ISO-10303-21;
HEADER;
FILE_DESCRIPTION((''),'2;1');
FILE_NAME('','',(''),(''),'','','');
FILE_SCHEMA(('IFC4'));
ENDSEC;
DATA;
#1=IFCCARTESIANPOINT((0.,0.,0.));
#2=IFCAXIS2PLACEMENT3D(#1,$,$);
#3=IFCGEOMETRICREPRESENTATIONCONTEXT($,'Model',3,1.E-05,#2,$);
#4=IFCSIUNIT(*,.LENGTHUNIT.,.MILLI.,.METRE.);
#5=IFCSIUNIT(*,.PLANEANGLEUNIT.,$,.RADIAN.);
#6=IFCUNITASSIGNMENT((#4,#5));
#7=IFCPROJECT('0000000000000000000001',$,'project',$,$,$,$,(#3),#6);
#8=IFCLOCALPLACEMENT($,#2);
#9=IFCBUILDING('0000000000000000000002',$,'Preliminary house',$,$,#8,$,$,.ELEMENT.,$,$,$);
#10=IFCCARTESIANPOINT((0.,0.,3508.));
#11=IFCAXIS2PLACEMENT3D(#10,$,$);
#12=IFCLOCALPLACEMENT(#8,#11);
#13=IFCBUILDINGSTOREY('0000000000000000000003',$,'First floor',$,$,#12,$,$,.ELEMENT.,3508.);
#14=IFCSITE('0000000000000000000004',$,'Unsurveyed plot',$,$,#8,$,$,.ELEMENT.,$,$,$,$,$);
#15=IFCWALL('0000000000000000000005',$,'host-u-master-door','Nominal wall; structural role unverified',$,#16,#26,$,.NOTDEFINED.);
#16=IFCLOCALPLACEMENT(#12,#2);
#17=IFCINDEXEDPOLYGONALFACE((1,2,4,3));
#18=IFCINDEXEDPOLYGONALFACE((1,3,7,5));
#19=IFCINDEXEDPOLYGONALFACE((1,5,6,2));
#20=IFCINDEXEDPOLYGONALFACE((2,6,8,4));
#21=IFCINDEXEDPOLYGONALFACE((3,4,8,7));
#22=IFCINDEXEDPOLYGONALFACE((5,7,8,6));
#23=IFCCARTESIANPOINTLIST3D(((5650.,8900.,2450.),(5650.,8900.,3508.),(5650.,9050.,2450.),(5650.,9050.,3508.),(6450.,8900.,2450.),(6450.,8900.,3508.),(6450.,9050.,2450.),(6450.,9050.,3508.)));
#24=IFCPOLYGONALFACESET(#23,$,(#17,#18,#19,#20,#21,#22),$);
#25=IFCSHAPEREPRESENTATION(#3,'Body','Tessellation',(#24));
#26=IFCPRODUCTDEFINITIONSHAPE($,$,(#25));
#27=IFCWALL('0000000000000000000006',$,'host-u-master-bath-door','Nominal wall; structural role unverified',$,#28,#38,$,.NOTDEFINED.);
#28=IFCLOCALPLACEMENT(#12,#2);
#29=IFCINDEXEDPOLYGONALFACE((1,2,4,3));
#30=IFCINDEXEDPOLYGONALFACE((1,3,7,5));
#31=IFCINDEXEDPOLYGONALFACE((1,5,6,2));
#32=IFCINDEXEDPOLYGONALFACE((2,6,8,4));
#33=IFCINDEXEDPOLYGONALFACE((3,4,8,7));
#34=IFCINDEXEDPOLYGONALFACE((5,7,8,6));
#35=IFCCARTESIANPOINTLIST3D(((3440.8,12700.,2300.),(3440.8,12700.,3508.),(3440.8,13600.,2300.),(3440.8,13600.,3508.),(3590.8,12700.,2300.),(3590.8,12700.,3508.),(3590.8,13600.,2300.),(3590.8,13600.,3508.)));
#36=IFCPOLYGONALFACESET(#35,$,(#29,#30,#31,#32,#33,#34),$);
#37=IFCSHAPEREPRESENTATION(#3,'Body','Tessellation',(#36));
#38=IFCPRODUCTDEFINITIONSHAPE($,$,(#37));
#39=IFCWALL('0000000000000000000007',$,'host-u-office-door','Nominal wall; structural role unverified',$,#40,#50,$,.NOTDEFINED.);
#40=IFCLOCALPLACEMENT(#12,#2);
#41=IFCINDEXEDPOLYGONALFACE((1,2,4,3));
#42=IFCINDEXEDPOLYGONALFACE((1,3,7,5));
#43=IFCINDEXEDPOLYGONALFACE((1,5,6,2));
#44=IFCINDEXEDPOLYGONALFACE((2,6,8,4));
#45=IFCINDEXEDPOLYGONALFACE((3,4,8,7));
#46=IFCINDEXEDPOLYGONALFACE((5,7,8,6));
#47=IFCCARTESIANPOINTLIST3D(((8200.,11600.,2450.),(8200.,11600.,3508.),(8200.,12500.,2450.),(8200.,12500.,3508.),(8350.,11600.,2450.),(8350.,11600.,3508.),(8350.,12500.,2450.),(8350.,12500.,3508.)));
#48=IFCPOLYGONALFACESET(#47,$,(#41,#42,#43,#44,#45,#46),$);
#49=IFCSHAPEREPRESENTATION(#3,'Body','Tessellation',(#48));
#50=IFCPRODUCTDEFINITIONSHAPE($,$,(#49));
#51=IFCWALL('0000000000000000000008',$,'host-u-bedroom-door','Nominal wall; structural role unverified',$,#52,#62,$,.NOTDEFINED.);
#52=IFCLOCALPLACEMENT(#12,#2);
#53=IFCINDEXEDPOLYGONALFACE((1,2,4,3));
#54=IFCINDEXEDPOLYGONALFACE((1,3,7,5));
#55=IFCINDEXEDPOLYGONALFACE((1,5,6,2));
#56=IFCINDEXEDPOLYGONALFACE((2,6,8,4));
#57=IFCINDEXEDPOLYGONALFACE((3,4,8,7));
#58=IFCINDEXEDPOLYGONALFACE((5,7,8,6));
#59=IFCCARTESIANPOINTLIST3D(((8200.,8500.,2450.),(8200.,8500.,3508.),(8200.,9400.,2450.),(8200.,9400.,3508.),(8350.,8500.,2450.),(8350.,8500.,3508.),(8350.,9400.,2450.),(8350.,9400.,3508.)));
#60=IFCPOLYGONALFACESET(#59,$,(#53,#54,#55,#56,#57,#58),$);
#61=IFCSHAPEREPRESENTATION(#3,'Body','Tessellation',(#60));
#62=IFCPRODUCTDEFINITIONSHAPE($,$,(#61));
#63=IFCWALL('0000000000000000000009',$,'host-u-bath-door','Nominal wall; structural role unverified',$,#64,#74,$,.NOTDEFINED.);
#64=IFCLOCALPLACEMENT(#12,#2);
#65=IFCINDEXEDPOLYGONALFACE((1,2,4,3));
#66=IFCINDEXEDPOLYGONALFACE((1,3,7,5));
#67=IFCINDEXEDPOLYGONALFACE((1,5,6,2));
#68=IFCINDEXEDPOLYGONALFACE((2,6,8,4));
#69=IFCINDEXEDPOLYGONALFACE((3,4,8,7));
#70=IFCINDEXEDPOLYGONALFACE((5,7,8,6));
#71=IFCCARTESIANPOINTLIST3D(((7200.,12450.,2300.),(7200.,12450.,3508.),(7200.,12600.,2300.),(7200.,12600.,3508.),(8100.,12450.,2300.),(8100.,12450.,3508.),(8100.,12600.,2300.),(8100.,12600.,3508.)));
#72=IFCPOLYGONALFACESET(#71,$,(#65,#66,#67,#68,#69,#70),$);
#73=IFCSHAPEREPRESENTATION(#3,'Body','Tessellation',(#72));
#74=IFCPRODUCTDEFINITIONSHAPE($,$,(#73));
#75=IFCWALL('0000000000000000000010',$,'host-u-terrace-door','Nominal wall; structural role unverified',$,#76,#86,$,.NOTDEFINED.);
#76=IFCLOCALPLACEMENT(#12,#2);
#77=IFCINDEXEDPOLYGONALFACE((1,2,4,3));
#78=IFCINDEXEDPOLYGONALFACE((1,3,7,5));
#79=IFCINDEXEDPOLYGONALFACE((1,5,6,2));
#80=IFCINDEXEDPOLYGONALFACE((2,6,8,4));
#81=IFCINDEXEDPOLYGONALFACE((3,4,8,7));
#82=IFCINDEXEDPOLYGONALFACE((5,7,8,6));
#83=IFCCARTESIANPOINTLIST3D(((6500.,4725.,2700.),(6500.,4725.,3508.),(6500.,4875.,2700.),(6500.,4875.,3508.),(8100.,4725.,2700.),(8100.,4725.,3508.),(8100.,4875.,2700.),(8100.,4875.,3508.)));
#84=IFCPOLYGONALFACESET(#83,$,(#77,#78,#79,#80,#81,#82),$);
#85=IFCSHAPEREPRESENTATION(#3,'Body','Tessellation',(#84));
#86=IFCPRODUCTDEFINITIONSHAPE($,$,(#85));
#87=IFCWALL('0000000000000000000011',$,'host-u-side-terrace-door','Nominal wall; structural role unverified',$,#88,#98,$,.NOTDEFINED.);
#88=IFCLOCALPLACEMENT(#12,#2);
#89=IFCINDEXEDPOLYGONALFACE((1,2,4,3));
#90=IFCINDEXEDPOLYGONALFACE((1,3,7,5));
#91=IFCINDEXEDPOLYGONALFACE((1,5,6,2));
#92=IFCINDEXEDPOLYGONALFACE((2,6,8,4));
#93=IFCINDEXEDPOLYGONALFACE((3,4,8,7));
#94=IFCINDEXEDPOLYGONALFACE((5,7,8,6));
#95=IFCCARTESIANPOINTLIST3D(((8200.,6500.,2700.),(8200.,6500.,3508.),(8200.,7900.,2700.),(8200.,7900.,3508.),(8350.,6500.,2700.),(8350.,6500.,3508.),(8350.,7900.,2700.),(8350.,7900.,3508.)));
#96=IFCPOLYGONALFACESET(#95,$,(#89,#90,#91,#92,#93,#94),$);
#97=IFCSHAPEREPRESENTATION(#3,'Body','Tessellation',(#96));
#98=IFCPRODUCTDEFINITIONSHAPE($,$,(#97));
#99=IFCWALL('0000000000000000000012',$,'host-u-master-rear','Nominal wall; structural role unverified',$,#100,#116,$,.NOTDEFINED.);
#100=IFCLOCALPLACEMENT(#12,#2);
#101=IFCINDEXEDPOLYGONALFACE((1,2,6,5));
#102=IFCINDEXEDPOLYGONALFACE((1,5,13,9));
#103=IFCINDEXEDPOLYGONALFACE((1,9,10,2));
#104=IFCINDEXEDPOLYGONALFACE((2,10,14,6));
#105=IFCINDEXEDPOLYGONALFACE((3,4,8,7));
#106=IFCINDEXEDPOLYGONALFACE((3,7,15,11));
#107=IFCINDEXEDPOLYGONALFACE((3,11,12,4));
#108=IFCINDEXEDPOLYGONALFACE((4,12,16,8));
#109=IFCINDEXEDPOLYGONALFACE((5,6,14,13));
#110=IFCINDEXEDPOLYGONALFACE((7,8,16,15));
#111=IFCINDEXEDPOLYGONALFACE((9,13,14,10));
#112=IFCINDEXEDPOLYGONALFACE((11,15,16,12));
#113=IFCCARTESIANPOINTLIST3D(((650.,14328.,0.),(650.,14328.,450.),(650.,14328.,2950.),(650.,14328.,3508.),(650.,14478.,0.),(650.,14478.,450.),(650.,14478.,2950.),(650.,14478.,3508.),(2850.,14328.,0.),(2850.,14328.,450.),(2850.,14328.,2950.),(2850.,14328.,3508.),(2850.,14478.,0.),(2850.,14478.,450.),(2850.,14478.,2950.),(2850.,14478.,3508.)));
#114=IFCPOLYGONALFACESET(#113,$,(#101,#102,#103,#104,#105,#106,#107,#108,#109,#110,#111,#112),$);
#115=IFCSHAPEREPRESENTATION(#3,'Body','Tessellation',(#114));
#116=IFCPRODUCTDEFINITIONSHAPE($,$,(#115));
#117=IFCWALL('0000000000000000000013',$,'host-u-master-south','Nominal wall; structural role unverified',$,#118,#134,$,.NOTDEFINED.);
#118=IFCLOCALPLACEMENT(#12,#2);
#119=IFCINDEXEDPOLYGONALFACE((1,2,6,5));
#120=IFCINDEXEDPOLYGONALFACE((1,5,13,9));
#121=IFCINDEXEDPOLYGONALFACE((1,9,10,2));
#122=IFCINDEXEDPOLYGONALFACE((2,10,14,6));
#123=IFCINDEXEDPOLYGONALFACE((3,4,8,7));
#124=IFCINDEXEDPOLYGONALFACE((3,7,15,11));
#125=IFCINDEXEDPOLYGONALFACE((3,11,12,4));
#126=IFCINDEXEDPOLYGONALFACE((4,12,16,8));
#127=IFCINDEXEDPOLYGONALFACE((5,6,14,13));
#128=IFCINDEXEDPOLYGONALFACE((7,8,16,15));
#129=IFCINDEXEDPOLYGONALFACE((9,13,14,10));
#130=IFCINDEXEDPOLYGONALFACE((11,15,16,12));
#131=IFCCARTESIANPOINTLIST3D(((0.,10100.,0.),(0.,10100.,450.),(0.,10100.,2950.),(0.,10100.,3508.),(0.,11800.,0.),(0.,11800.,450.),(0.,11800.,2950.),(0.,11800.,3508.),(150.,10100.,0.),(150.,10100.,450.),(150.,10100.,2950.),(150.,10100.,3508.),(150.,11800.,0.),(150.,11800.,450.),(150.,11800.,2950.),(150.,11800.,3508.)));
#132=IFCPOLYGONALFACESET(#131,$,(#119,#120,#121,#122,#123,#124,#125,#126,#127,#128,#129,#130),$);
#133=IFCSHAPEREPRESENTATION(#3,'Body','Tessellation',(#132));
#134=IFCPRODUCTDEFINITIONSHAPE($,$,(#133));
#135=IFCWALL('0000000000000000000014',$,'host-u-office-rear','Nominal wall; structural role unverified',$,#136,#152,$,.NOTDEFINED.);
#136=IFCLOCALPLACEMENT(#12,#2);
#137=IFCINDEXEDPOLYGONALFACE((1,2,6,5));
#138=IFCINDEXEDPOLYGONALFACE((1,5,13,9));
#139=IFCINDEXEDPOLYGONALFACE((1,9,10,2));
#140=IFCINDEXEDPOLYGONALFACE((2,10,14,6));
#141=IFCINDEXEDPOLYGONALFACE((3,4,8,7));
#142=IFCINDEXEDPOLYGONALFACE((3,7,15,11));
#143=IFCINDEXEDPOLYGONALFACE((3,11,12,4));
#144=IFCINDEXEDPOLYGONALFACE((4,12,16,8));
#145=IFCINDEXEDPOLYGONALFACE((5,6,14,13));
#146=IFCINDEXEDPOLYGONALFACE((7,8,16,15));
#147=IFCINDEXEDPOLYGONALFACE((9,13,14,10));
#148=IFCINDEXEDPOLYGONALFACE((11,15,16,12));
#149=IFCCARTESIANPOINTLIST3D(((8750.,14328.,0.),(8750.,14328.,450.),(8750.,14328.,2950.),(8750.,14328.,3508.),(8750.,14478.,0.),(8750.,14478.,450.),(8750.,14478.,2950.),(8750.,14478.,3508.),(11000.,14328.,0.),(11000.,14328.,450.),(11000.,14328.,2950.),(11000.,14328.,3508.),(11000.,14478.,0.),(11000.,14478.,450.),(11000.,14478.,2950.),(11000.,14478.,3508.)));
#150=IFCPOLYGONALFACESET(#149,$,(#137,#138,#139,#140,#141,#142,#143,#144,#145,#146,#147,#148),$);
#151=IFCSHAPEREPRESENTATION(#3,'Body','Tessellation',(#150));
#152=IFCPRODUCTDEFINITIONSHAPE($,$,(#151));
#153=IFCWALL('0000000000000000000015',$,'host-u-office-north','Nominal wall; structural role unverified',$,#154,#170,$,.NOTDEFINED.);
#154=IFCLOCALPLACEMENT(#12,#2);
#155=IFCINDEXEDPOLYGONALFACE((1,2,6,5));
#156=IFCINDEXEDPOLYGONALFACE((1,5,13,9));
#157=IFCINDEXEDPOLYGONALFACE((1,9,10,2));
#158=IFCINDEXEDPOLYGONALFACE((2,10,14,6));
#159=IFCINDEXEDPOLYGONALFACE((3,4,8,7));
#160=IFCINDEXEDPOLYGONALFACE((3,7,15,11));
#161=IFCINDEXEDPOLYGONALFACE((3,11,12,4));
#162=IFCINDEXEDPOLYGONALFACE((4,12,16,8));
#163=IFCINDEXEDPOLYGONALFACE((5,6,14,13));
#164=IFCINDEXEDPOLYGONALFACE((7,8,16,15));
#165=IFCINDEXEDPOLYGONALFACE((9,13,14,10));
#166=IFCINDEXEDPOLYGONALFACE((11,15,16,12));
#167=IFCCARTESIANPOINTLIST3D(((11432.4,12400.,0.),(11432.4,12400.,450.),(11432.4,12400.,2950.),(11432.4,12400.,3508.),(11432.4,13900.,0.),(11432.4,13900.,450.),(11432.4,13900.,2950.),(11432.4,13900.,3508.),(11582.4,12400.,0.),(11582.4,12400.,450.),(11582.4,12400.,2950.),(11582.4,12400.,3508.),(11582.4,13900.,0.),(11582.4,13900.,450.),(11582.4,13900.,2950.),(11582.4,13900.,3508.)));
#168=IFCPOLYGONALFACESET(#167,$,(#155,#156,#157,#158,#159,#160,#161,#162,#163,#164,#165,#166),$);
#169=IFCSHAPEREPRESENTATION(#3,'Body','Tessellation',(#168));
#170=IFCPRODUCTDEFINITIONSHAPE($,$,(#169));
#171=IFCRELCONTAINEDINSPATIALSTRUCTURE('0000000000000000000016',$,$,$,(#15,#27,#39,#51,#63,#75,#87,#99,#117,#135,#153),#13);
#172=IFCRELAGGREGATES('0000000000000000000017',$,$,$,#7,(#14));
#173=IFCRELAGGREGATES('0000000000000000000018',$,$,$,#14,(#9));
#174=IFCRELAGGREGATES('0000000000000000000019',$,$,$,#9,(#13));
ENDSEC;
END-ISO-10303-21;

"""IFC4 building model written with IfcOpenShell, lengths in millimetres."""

from ifc_helpers import new_model, si_unit, frame, origin, place, context, project, spatial, polyline, outline, extrude, element, save


model = new_model("IFC4")

# Units and contexts
model_context = context("Model", 3, precision=1e-05, world=origin())
ifc_project = project(units=[si_unit("LENGTHUNIT", "METRE", prefix="MILLI"), si_unit("PLANEANGLEUNIT", "RADIAN")], contexts=[model_context])

# Site, building, storey
placement_1 = place(None, origin())
site = spatial("IfcSite", under=ifc_project, at=placement_1, Name="Unsurveyed plot", CompositionType="ELEMENT")
building = spatial("IfcBuilding", under=site, at=placement_1, Name="Preliminary house", CompositionType="ELEMENT")
placement_2 = place(placement_1, frame((0.0, 0.0, 3508.0)))
storey = spatial("IfcBuildingStorey", under=building, at=placement_2, Name="First floor", CompositionType="ELEMENT", Elevation=3508.0)

# Walls, openings
wall_1 = element("IfcWall", 1, at=placement_2, inside=storey, Name="host-u-master-door", Description="Nominal wall; structural role unverified", PredefinedType="NOTDEFINED", context=model_context, shape_type="SweptSolid", body=[
    extrude(outline(polyline([(6450.0, 9050.0), (6450.0, 8900.0), (5650.0, 8900.0), (5650.0, 9050.0), (6450.0, 9050.0)])), origin(), (0.0, 0.0, 1.0), 3508.0),
])
element("IfcOpeningElement", 2, at=placement_2, cuts=wall_1, PredefinedType="OPENING", context=model_context, shape_type="SweptSolid", body=[
    extrude(outline(polyline([(5650.0, 8525.0), (6450.0, 8525.0), (6450.0, 9425.0), (5650.0, 9425.0), (5650.0, 8525.0)])), origin(), (0.0, 0.0, 1.0), 2450.0),
])
wall_2 = element("IfcWall", 3, at=placement_2, inside=storey, Name="host-u-master-bath-door", Description="Nominal wall; structural role unverified", PredefinedType="NOTDEFINED", context=model_context, shape_type="SweptSolid", body=[
    extrude(outline(polyline([(3440.8, 13600.0), (3590.8, 13600.0), (3590.8, 12700.0), (3440.8, 12700.0), (3440.8, 13600.0)])), origin(), (0.0, 0.0, 1.0), 3508.0),
])
element("IfcOpeningElement", 4, at=placement_2, cuts=wall_2, PredefinedType="OPENING", context=model_context, shape_type="SweptSolid", body=[
    extrude(outline(polyline([(3965.8, 12700.0), (3965.8, 13600.0), (3065.8, 13600.0), (3065.8, 12700.0), (3965.8, 12700.0)])), origin(), (0.0, 0.0, 1.0), 2300.0),
])
wall_3 = element("IfcWall", 5, at=placement_2, inside=storey, Name="host-u-office-door", Description="Nominal wall; structural role unverified", PredefinedType="NOTDEFINED", context=model_context, shape_type="SweptSolid", body=[
    extrude(outline(polyline([(8200.0, 12500.0), (8350.0, 12500.0), (8350.0, 11600.0), (8200.0, 11600.0), (8200.0, 12500.0)])), origin(), (0.0, 0.0, 1.0), 3508.0),
])
element("IfcOpeningElement", 6, at=placement_2, cuts=wall_3, PredefinedType="OPENING", context=model_context, shape_type="SweptSolid", body=[
    extrude(outline(polyline([(8725.0, 11600.0), (8725.0, 12500.0), (7825.0, 12500.0), (7825.0, 11600.0), (8725.0, 11600.0)])), origin(), (0.0, 0.0, 1.0), 2450.0),
])
wall_4 = element("IfcWall", 7, at=placement_2, inside=storey, Name="host-u-bedroom-door", Description="Nominal wall; structural role unverified", PredefinedType="NOTDEFINED", context=model_context, shape_type="SweptSolid", body=[
    extrude(outline(polyline([(8200.0, 9400.0), (8350.0, 9400.0), (8350.0, 8500.0), (8200.0, 8500.0), (8200.0, 9400.0)])), origin(), (0.0, 0.0, 1.0), 3508.0),
])
element("IfcOpeningElement", 8, at=placement_2, cuts=wall_4, PredefinedType="OPENING", context=model_context, shape_type="SweptSolid", body=[
    extrude(outline(polyline([(8725.0, 8500.0), (8725.0, 9400.0), (7825.0, 9400.0), (7825.0, 8500.0), (8725.0, 8500.0)])), origin(), (0.0, 0.0, 1.0), 2450.0),
])
wall_5 = element("IfcWall", 9, at=placement_2, inside=storey, Name="host-u-bath-door", Description="Nominal wall; structural role unverified", PredefinedType="NOTDEFINED", context=model_context, shape_type="SweptSolid", body=[
    extrude(outline(polyline([(8100.0, 12600.0), (8100.0, 12450.0), (7200.0, 12450.0), (7200.0, 12600.0), (8100.0, 12600.0)])), origin(), (0.0, 0.0, 1.0), 3508.0),
])
element("IfcOpeningElement", 10, at=placement_2, cuts=wall_5, PredefinedType="OPENING", context=model_context, shape_type="SweptSolid", body=[
    extrude(outline(polyline([(7200.0, 12075.0), (8100.0, 12075.0), (8100.0, 12975.0), (7200.0, 12975.0), (7200.0, 12075.0)])), origin(), (0.0, 0.0, 1.0), 2300.0),
])
wall_6 = element("IfcWall", 11, at=placement_2, inside=storey, Name="host-u-terrace-door", Description="Nominal wall; structural role unverified", PredefinedType="NOTDEFINED", context=model_context, shape_type="SweptSolid", body=[
    extrude(outline(polyline([(8100.0, 4875.0), (8100.0, 4725.0), (6500.0, 4725.0), (6500.0, 4875.0), (8100.0, 4875.0)])), origin(), (0.0, 0.0, 1.0), 3508.0),
])
element("IfcOpeningElement", 12, at=placement_2, cuts=wall_6, PredefinedType="OPENING", context=model_context, shape_type="SweptSolid", body=[
    extrude(outline(polyline([(6500.0, 4350.0), (8100.0, 4350.0), (8100.0, 5250.0), (6500.0, 5250.0), (6500.0, 4350.0)])), origin(), (0.0, 0.0, 1.0), 2700.0),
])
wall_7 = element("IfcWall", 13, at=placement_2, inside=storey, Name="host-u-side-terrace-door", Description="Nominal wall; structural role unverified", PredefinedType="NOTDEFINED", context=model_context, shape_type="SweptSolid", body=[
    extrude(outline(polyline([(8200.0, 7900.0), (8350.0, 7900.0), (8350.0, 6500.0), (8200.0, 6500.0), (8200.0, 7900.0)])), origin(), (0.0, 0.0, 1.0), 3508.0),
])
element("IfcOpeningElement", 14, at=placement_2, cuts=wall_7, PredefinedType="OPENING", context=model_context, shape_type="SweptSolid", body=[
    extrude(outline(polyline([(8725.0, 6500.0), (8725.0, 7900.0), (7825.0, 7900.0), (7825.0, 6500.0), (8725.0, 6500.0)])), origin(), (0.0, 0.0, 1.0), 2700.0),
])
wall_8 = element("IfcWall", 15, at=placement_2, inside=storey, Name="host-u-master-rear", Description="Nominal wall; structural role unverified", PredefinedType="NOTDEFINED", context=model_context, shape_type="SweptSolid", body=[
    extrude(outline(polyline([(2850.0, 14478.0), (2850.0, 14328.0), (650.0, 14328.0), (650.0, 14478.0), (2850.0, 14478.0)])), origin(), (0.0, 0.0, 1.0), 3508.0),
])
element("IfcOpeningElement", 16, at=placement_2, cuts=wall_8, PredefinedType="OPENING", context=model_context, shape_type="SweptSolid", body=[
    extrude(outline(polyline([(650.0, 13953.0), (2850.0, 13953.0), (2850.0, 14853.0), (650.0, 14853.0), (650.0, 13953.0)])), frame((0.0, 0.0, 450.0)), (0.0, 0.0, 1.0), 2500.0),
])
wall_9 = element("IfcWall", 17, at=placement_2, inside=storey, Name="host-u-master-south", Description="Nominal wall; structural role unverified", PredefinedType="NOTDEFINED", context=model_context, shape_type="SweptSolid", body=[
    extrude(outline(polyline([(0.0, 11800.0), (150.0, 11800.0), (150.0, 10100.0), (0.0, 10100.0), (0.0, 11800.0)])), origin(), (0.0, 0.0, 1.0), 3508.0),
])
element("IfcOpeningElement", 18, at=placement_2, cuts=wall_9, PredefinedType="OPENING", context=model_context, shape_type="SweptSolid", body=[
    extrude(outline(polyline([(525.0, 10100.0), (525.0, 11800.0), (-375.0, 11800.0), (-375.0, 10100.0), (525.0, 10100.0)])), frame((0.0, 0.0, 450.0)), (0.0, 0.0, 1.0), 2500.0),
])
wall_10 = element("IfcWall", 19, at=placement_2, inside=storey, Name="host-u-office-rear", Description="Nominal wall; structural role unverified", PredefinedType="NOTDEFINED", context=model_context, shape_type="SweptSolid", body=[
    extrude(outline(polyline([(11000.0, 14478.0), (11000.0, 14328.0), (8750.0, 14328.0), (8750.0, 14478.0), (11000.0, 14478.0)])), origin(), (0.0, 0.0, 1.0), 3508.0),
])
element("IfcOpeningElement", 20, at=placement_2, cuts=wall_10, PredefinedType="OPENING", context=model_context, shape_type="SweptSolid", body=[
    extrude(outline(polyline([(8750.0, 13953.0), (11000.0, 13953.0), (11000.0, 14853.0), (8750.0, 14853.0), (8750.0, 13953.0)])), frame((0.0, 0.0, 450.0)), (0.0, 0.0, 1.0), 2500.0),
])
wall_11 = element("IfcWall", 21, at=placement_2, inside=storey, Name="host-u-office-north", Description="Nominal wall; structural role unverified", PredefinedType="NOTDEFINED", context=model_context, shape_type="SweptSolid", body=[
    extrude(outline(polyline([(11432.4, 13900.0), (11582.4, 13900.0), (11582.4, 12400.0), (11432.4, 12400.0), (11432.4, 13900.0)])), origin(), (0.0, 0.0, 1.0), 3508.0),
])
element("IfcOpeningElement", 22, at=placement_2, cuts=wall_11, PredefinedType="OPENING", context=model_context, shape_type="SweptSolid", body=[
    extrude(outline(polyline([(11957.4, 12400.0), (11957.4, 13900.0), (11057.4, 13900.0), (11057.4, 12400.0), (11957.4, 12400.0)])), frame((0.0, 0.0, 450.0)), (0.0, 0.0, 1.0), 2500.0),
])

save(model, "model.ifc")
